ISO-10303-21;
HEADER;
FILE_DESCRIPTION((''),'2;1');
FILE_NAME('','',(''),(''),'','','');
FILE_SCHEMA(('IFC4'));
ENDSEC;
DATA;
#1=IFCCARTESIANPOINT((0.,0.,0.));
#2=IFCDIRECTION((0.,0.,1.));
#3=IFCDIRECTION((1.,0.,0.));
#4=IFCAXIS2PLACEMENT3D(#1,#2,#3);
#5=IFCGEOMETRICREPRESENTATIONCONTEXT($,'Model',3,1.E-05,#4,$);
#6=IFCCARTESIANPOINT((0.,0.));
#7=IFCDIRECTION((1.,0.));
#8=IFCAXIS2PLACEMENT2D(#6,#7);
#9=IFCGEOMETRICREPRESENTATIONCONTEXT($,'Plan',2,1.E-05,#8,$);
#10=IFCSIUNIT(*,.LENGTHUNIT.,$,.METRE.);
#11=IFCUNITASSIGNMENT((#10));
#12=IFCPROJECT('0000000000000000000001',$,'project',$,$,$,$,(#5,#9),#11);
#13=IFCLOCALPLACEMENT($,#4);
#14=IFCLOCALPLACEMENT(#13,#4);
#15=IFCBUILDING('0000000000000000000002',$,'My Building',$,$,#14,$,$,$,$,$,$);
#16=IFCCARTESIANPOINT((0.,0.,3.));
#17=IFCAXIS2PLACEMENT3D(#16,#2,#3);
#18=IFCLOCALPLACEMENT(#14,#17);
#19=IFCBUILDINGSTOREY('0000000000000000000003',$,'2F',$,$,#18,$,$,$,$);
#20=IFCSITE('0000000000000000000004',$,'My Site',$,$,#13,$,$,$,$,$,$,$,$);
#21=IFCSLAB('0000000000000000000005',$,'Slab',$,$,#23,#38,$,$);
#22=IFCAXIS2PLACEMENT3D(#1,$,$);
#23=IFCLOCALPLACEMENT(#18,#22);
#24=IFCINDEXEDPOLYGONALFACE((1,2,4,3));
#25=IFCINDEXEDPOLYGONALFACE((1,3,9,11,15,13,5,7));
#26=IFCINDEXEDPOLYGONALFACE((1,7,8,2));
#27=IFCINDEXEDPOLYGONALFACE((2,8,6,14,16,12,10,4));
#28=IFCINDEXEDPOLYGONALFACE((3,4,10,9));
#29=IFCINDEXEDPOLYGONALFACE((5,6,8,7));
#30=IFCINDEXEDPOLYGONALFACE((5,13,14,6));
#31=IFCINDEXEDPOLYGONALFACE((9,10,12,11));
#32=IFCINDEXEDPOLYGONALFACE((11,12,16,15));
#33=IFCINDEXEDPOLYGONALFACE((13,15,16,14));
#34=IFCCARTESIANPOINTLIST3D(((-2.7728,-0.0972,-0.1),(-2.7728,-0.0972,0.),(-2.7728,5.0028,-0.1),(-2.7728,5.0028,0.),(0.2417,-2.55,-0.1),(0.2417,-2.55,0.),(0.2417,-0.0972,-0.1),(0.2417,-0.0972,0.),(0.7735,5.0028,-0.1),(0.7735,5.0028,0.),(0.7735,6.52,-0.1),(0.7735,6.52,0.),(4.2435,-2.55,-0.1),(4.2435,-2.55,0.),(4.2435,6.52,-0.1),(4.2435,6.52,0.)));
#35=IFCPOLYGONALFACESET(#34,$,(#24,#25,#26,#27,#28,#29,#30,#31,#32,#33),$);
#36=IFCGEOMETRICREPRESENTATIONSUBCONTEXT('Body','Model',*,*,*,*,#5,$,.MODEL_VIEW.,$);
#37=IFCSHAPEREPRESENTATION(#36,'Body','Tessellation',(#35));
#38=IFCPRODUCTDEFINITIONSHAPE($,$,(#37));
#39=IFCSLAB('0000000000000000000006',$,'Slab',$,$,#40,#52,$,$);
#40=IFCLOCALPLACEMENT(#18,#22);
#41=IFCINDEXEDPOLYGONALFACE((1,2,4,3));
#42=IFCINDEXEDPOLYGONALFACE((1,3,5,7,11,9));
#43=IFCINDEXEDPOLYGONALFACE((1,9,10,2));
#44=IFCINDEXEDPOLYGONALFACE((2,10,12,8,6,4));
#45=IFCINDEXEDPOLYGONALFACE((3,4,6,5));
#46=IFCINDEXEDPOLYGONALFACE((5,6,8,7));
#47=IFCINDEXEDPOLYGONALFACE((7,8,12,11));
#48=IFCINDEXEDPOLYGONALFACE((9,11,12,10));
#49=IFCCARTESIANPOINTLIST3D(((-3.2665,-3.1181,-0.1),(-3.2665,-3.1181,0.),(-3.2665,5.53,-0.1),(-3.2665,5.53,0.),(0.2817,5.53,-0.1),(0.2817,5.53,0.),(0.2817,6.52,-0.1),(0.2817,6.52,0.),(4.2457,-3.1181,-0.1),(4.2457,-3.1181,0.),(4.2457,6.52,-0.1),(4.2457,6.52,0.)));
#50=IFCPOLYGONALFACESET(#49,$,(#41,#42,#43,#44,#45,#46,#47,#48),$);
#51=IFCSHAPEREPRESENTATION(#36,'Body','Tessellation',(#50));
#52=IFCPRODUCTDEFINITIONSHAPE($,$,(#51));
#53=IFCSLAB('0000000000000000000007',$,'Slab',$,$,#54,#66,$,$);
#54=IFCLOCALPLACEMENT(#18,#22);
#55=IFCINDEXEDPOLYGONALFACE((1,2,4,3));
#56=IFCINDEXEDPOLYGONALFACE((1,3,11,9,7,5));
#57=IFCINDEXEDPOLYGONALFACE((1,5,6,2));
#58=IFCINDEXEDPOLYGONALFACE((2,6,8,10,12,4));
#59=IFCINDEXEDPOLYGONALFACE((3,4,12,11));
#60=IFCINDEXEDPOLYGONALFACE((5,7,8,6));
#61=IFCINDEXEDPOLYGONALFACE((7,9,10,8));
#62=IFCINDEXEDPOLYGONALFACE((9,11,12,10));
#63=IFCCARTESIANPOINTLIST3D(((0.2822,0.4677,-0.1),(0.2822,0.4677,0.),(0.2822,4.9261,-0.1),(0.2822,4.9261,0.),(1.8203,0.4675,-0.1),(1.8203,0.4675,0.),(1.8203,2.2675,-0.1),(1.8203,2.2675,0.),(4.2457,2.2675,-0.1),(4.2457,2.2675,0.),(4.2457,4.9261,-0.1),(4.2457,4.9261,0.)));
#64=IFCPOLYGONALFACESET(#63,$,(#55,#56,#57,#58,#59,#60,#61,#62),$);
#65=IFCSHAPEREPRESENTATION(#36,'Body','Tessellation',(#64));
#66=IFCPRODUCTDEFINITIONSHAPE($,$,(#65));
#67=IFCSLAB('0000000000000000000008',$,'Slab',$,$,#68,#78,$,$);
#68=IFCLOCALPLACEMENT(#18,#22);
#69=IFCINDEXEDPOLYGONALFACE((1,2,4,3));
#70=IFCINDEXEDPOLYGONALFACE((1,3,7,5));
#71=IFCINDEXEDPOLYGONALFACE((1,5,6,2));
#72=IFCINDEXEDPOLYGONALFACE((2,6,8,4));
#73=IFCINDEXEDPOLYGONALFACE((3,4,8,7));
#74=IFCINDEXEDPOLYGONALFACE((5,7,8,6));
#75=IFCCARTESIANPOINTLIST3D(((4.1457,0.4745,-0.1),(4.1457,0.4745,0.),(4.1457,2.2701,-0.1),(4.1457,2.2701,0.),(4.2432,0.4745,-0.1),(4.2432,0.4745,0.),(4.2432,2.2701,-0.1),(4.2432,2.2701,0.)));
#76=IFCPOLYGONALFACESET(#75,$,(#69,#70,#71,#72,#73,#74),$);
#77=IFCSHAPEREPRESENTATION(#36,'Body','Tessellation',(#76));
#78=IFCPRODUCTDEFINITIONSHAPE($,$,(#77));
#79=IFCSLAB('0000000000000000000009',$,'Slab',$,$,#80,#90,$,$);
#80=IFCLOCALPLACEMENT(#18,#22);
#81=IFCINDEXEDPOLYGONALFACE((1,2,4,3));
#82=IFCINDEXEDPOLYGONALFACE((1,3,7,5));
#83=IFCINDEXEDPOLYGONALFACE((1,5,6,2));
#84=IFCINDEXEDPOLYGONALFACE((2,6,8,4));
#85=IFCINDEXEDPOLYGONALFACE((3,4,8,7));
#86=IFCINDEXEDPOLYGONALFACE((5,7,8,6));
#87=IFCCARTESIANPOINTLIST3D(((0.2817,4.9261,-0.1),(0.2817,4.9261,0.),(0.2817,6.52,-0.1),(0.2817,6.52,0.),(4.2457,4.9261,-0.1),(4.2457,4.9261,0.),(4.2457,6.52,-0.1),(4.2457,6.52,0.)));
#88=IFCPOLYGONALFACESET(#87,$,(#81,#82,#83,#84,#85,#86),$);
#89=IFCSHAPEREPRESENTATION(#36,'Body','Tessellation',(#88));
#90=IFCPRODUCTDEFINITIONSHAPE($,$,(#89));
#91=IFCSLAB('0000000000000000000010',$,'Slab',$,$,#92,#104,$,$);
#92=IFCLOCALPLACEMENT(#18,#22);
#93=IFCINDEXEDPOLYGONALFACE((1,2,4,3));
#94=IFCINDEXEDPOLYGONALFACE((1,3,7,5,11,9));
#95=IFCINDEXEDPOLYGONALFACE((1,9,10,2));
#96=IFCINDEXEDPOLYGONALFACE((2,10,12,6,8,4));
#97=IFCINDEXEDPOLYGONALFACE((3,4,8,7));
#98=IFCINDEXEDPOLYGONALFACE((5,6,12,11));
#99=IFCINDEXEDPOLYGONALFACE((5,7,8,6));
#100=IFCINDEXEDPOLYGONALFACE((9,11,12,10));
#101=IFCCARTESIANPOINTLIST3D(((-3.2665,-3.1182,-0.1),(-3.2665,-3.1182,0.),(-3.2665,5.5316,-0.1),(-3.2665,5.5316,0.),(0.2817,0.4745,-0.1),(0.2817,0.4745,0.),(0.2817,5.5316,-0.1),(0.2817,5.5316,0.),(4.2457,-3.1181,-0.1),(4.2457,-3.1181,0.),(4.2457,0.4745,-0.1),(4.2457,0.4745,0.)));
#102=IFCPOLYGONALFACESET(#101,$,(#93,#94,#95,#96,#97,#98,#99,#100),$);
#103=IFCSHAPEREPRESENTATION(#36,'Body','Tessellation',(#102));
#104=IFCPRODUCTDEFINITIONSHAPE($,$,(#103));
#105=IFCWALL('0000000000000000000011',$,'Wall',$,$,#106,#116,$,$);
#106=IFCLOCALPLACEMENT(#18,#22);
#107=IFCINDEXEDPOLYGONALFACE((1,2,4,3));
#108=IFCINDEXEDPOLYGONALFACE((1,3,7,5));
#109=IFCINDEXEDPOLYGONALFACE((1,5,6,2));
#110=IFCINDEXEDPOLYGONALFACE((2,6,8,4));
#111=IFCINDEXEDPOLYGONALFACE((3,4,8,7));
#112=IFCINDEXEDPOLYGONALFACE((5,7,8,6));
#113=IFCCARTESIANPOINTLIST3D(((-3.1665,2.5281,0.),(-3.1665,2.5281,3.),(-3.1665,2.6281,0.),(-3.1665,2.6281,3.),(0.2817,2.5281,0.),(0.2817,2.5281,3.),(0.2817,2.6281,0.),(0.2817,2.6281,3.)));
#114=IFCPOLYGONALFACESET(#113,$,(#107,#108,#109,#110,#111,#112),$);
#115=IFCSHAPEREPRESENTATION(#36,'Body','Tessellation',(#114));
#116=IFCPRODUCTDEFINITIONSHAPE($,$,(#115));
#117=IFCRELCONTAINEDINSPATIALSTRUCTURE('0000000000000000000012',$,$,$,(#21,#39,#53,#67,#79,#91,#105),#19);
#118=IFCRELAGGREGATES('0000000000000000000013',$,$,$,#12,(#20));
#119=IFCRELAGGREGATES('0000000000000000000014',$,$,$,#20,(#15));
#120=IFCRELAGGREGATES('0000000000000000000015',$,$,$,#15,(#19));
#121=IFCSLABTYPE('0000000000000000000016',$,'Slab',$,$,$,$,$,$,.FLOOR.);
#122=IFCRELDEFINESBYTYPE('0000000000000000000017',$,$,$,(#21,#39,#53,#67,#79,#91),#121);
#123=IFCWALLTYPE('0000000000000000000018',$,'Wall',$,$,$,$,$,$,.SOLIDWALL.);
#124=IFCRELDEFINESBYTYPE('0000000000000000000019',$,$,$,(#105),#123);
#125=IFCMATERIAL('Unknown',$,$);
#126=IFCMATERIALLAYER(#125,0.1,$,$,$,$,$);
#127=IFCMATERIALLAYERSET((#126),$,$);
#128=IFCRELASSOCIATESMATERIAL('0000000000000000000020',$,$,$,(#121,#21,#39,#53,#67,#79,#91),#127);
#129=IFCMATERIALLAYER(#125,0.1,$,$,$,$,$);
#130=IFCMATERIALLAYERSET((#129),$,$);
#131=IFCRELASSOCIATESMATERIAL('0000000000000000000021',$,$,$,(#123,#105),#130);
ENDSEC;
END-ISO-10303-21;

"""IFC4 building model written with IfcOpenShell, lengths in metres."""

from ifc_helpers import new_model, si_unit, frame, origin_with_axes, origin_2d_with_axis, place, context, subcontext, project, spatial, line, indexed_curve, outline, extrude, material, layer, layer_set, layer_usage, type_object, element, save


model = new_model("IFC4")

# Units and contexts
model_context = context("Model", 3, precision=1e-05, world=origin_with_axes())
plan_context = context("Plan", 2, precision=1e-05, world=origin_2d_with_axis())
body_context_1 = subcontext(model_context, "Body", "Model", "MODEL_VIEW")
ifc_project = project(units=[si_unit("LENGTHUNIT", "METRE")], contexts=[model_context, plan_context])

# Site, building, storey
site_placement = place(None, origin_with_axes())
site = spatial("IfcSite", under=ifc_project, at=site_placement, Name="My Site")
building_placement = place(site_placement, origin_with_axes())
building = spatial("IfcBuilding", under=site, at=building_placement, Name="My Building")
storey_placement = place(building_placement, frame((0.0, 0.0, 3.0), z_axis=(0.0, 0.0, 1.0), x_axis=(1.0, 0.0, 0.0)))
storey = spatial("IfcBuildingStorey", under=building, at=storey_placement, Name="2F")

# Slabs
ifc_material = material(Name="Unknown")
ifc_layer_1 = layer(ifc_material, 0.1)
ifc_layer_set_1 = layer_set([ifc_layer_1])
ifc_layer_usage_1 = layer_usage(ifc_layer_set_1, "AXIS3", "POSITIVE", -0.1)
slab_type = type_object("IfcSlabType", Name="Slab", PredefinedType="FLOOR", material=ifc_layer_set_1)
slab_1_placement = place(storey_placement, frame((4.2435, -2.55, 0.0), z_axis=(0.0, 0.0, 1.0), x_axis=(1.0, 0.0, 0.0)))
element("IfcSlab", 1, at=slab_1_placement, inside=storey, type_object=slab_type, material=ifc_layer_usage_1, Name="Slab", context=body_context_1, shape_type="SweptSolid", body=[
    extrude(outline(indexed_curve([(0.0, 0.0), (0.0, 9.07), (-3.47, 9.07), (-3.47, 7.5528), (-7.0163, 7.5528), (-7.0163, 2.4528), (-4.0018, 2.4528), (-4.0018, 0.0), (0.0, 0.0)])), frame((0.0, 0.0, -0.1), z_axis=(0.0, 0.0, 1.0), x_axis=(1.0, 0.0, 0.0)), (0.0, 0.0, 1.0), 0.1),
])
ifc_layer_usage_2 = layer_usage(ifc_layer_set_1, "AXIS3", "POSITIVE", -0.1)
slab_2_placement = place(storey_placement, frame((4.2457, -3.1181, 0.0), z_axis=(0.0, 0.0, 1.0), x_axis=(1.0, 0.0, 0.0)))
element("IfcSlab", 2, at=slab_2_placement, inside=storey, type_object=slab_type, material=ifc_layer_usage_2, Name="Slab", context=body_context_1, shape_type="SweptSolid", body=[
    extrude(outline(indexed_curve([(0.0, 0.0), (0.0, 9.6381), (-3.964, 9.6381), (-3.964, 8.6481), (-7.5122, 8.6481), (-7.5122, 0.0), (0.0, 0.0)])), frame((0.0, 0.0, -0.1), z_axis=(0.0, 0.0, 1.0), x_axis=(1.0, 0.0, 0.0)), (0.0, 0.0, 1.0), 0.1),
])
ifc_layer_usage_3 = layer_usage(ifc_layer_set_1, "AXIS3", "POSITIVE", -0.1)
slab_3_placement = place(storey_placement, frame((1.8203, 0.4675, 0.0), z_axis=(0.0, 0.0, 1.0), x_axis=(1.0, 0.0, 0.0)))
element("IfcSlab", 3, at=slab_3_placement, inside=storey, type_object=slab_type, material=ifc_layer_usage_3, Name="Slab", context=body_context_1, shape_type="SweptSolid", body=[
    extrude(outline(indexed_curve([(0.0, 0.0), (0.0, 1.8), (2.4254, 1.8), (2.4254, 4.4586), (-1.5381, 4.4586), (-1.5381, 0.0002), (0.0, 0.0)])), frame((0.0, 0.0, -0.1), z_axis=(0.0, 0.0, 1.0), x_axis=(1.0, 0.0, 0.0)), (0.0, 0.0, 1.0), 0.1),
])
ifc_layer_usage_4 = layer_usage(ifc_layer_set_1, "AXIS3", "POSITIVE", -0.1)
slab_4_placement = place(storey_placement, frame((4.1457, 0.4745, 0.0), z_axis=(0.0, 0.0, 1.0), x_axis=(1.0, 0.0, 0.0)))
element("IfcSlab", 4, at=slab_4_placement, inside=storey, type_object=slab_type, material=ifc_layer_usage_4, Name="Slab", context=body_context_1, shape_type="SweptSolid", body=[
    extrude(outline(indexed_curve([(0.0, 0.0), (0.0, 1.7956), (0.0975, 1.7956), (0.0975, -0.0001), (0.0, 0.0)])), frame((0.0, 0.0, -0.1), z_axis=(0.0, 0.0, 1.0), x_axis=(1.0, 0.0, 0.0)), (0.0, 0.0, 1.0), 0.1),
])
ifc_layer_usage_5 = layer_usage(ifc_layer_set_1, "AXIS3", "POSITIVE", -0.1)
slab_5_placement = place(storey_placement, frame((4.2457, 6.52, 0.0), z_axis=(0.0, 0.0, 1.0), x_axis=(1.0, 0.0, 0.0)))
element("IfcSlab", 5, at=slab_5_placement, inside=storey, type_object=slab_type, material=ifc_layer_usage_5, Name="Slab", context=body_context_1, shape_type="SweptSolid", body=[
    extrude(outline(indexed_curve([(0.0, 0.0), (-3.964, 0.0), (-3.964, -1.5939), (0.0, -1.5939), (0.0, 0.0)])), frame((0.0, 0.0, -0.1), z_axis=(0.0, 0.0, 1.0), x_axis=(1.0, 0.0, 0.0)), (0.0, 0.0, 1.0), 0.1),
])
ifc_layer_usage_6 = layer_usage(ifc_layer_set_1, "AXIS3", "POSITIVE", -0.1)
slab_6_placement = place(storey_placement, frame((4.2457, -3.1181, 0.0), z_axis=(0.0, 0.0, 1.0), x_axis=(1.0, 0.0, 0.0)))
element("IfcSlab", 6, at=slab_6_placement, inside=storey, type_object=slab_type, material=ifc_layer_usage_6, Name="Slab", context=body_context_1, shape_type="SweptSolid", body=[
    extrude(outline(indexed_curve([(0.0, 0.0), (0.0, 3.5926), (-3.964, 3.5926), (-3.964, 8.6496), (-7.5122, 8.6496), (-7.5122, -0.0001), (0.0, 0.0)])), frame((0.0, 0.0, -0.1), z_axis=(0.0, 0.0, 1.0), x_axis=(1.0, 0.0, 0.0)), (0.0, 0.0, 1.0), 0.1),
])

# Wall
ifc_layer_2 = layer(ifc_material, 0.1)
ifc_layer_set_2 = layer_set([ifc_layer_2])
ifc_layer_usage_7 = layer_usage(ifc_layer_set_2, "AXIS2", "POSITIVE", 0.0)
wall_type_1 = type_object("IfcWallType", Name="Wall", PredefinedType="SOLIDWALL", material=ifc_layer_set_2)
wall_1_placement = place(storey_placement, frame((0.2817, 2.6281, 0.0), z_axis=(0.0, 0.0, 1.0), x_axis=(-1.0, 0.0, 0.0)))
element("IfcWall", 7, at=wall_1_placement, inside=storey, type_object=wall_type_1, material=ifc_layer_usage_7, Name="Wall", context=body_context_1, shape_type="SweptSolid", body=[
    extrude(outline(indexed_curve([(0.0, 0.0), (0.0, 0.1), (3.4482, 0.1), (3.4482, 0.0)], segments=[line(1, 2, 3, 4, 1)])), origin_with_axes(), (0.0, 0.0, 1.0), 3.0),
])

save(model, "model.ifc")
